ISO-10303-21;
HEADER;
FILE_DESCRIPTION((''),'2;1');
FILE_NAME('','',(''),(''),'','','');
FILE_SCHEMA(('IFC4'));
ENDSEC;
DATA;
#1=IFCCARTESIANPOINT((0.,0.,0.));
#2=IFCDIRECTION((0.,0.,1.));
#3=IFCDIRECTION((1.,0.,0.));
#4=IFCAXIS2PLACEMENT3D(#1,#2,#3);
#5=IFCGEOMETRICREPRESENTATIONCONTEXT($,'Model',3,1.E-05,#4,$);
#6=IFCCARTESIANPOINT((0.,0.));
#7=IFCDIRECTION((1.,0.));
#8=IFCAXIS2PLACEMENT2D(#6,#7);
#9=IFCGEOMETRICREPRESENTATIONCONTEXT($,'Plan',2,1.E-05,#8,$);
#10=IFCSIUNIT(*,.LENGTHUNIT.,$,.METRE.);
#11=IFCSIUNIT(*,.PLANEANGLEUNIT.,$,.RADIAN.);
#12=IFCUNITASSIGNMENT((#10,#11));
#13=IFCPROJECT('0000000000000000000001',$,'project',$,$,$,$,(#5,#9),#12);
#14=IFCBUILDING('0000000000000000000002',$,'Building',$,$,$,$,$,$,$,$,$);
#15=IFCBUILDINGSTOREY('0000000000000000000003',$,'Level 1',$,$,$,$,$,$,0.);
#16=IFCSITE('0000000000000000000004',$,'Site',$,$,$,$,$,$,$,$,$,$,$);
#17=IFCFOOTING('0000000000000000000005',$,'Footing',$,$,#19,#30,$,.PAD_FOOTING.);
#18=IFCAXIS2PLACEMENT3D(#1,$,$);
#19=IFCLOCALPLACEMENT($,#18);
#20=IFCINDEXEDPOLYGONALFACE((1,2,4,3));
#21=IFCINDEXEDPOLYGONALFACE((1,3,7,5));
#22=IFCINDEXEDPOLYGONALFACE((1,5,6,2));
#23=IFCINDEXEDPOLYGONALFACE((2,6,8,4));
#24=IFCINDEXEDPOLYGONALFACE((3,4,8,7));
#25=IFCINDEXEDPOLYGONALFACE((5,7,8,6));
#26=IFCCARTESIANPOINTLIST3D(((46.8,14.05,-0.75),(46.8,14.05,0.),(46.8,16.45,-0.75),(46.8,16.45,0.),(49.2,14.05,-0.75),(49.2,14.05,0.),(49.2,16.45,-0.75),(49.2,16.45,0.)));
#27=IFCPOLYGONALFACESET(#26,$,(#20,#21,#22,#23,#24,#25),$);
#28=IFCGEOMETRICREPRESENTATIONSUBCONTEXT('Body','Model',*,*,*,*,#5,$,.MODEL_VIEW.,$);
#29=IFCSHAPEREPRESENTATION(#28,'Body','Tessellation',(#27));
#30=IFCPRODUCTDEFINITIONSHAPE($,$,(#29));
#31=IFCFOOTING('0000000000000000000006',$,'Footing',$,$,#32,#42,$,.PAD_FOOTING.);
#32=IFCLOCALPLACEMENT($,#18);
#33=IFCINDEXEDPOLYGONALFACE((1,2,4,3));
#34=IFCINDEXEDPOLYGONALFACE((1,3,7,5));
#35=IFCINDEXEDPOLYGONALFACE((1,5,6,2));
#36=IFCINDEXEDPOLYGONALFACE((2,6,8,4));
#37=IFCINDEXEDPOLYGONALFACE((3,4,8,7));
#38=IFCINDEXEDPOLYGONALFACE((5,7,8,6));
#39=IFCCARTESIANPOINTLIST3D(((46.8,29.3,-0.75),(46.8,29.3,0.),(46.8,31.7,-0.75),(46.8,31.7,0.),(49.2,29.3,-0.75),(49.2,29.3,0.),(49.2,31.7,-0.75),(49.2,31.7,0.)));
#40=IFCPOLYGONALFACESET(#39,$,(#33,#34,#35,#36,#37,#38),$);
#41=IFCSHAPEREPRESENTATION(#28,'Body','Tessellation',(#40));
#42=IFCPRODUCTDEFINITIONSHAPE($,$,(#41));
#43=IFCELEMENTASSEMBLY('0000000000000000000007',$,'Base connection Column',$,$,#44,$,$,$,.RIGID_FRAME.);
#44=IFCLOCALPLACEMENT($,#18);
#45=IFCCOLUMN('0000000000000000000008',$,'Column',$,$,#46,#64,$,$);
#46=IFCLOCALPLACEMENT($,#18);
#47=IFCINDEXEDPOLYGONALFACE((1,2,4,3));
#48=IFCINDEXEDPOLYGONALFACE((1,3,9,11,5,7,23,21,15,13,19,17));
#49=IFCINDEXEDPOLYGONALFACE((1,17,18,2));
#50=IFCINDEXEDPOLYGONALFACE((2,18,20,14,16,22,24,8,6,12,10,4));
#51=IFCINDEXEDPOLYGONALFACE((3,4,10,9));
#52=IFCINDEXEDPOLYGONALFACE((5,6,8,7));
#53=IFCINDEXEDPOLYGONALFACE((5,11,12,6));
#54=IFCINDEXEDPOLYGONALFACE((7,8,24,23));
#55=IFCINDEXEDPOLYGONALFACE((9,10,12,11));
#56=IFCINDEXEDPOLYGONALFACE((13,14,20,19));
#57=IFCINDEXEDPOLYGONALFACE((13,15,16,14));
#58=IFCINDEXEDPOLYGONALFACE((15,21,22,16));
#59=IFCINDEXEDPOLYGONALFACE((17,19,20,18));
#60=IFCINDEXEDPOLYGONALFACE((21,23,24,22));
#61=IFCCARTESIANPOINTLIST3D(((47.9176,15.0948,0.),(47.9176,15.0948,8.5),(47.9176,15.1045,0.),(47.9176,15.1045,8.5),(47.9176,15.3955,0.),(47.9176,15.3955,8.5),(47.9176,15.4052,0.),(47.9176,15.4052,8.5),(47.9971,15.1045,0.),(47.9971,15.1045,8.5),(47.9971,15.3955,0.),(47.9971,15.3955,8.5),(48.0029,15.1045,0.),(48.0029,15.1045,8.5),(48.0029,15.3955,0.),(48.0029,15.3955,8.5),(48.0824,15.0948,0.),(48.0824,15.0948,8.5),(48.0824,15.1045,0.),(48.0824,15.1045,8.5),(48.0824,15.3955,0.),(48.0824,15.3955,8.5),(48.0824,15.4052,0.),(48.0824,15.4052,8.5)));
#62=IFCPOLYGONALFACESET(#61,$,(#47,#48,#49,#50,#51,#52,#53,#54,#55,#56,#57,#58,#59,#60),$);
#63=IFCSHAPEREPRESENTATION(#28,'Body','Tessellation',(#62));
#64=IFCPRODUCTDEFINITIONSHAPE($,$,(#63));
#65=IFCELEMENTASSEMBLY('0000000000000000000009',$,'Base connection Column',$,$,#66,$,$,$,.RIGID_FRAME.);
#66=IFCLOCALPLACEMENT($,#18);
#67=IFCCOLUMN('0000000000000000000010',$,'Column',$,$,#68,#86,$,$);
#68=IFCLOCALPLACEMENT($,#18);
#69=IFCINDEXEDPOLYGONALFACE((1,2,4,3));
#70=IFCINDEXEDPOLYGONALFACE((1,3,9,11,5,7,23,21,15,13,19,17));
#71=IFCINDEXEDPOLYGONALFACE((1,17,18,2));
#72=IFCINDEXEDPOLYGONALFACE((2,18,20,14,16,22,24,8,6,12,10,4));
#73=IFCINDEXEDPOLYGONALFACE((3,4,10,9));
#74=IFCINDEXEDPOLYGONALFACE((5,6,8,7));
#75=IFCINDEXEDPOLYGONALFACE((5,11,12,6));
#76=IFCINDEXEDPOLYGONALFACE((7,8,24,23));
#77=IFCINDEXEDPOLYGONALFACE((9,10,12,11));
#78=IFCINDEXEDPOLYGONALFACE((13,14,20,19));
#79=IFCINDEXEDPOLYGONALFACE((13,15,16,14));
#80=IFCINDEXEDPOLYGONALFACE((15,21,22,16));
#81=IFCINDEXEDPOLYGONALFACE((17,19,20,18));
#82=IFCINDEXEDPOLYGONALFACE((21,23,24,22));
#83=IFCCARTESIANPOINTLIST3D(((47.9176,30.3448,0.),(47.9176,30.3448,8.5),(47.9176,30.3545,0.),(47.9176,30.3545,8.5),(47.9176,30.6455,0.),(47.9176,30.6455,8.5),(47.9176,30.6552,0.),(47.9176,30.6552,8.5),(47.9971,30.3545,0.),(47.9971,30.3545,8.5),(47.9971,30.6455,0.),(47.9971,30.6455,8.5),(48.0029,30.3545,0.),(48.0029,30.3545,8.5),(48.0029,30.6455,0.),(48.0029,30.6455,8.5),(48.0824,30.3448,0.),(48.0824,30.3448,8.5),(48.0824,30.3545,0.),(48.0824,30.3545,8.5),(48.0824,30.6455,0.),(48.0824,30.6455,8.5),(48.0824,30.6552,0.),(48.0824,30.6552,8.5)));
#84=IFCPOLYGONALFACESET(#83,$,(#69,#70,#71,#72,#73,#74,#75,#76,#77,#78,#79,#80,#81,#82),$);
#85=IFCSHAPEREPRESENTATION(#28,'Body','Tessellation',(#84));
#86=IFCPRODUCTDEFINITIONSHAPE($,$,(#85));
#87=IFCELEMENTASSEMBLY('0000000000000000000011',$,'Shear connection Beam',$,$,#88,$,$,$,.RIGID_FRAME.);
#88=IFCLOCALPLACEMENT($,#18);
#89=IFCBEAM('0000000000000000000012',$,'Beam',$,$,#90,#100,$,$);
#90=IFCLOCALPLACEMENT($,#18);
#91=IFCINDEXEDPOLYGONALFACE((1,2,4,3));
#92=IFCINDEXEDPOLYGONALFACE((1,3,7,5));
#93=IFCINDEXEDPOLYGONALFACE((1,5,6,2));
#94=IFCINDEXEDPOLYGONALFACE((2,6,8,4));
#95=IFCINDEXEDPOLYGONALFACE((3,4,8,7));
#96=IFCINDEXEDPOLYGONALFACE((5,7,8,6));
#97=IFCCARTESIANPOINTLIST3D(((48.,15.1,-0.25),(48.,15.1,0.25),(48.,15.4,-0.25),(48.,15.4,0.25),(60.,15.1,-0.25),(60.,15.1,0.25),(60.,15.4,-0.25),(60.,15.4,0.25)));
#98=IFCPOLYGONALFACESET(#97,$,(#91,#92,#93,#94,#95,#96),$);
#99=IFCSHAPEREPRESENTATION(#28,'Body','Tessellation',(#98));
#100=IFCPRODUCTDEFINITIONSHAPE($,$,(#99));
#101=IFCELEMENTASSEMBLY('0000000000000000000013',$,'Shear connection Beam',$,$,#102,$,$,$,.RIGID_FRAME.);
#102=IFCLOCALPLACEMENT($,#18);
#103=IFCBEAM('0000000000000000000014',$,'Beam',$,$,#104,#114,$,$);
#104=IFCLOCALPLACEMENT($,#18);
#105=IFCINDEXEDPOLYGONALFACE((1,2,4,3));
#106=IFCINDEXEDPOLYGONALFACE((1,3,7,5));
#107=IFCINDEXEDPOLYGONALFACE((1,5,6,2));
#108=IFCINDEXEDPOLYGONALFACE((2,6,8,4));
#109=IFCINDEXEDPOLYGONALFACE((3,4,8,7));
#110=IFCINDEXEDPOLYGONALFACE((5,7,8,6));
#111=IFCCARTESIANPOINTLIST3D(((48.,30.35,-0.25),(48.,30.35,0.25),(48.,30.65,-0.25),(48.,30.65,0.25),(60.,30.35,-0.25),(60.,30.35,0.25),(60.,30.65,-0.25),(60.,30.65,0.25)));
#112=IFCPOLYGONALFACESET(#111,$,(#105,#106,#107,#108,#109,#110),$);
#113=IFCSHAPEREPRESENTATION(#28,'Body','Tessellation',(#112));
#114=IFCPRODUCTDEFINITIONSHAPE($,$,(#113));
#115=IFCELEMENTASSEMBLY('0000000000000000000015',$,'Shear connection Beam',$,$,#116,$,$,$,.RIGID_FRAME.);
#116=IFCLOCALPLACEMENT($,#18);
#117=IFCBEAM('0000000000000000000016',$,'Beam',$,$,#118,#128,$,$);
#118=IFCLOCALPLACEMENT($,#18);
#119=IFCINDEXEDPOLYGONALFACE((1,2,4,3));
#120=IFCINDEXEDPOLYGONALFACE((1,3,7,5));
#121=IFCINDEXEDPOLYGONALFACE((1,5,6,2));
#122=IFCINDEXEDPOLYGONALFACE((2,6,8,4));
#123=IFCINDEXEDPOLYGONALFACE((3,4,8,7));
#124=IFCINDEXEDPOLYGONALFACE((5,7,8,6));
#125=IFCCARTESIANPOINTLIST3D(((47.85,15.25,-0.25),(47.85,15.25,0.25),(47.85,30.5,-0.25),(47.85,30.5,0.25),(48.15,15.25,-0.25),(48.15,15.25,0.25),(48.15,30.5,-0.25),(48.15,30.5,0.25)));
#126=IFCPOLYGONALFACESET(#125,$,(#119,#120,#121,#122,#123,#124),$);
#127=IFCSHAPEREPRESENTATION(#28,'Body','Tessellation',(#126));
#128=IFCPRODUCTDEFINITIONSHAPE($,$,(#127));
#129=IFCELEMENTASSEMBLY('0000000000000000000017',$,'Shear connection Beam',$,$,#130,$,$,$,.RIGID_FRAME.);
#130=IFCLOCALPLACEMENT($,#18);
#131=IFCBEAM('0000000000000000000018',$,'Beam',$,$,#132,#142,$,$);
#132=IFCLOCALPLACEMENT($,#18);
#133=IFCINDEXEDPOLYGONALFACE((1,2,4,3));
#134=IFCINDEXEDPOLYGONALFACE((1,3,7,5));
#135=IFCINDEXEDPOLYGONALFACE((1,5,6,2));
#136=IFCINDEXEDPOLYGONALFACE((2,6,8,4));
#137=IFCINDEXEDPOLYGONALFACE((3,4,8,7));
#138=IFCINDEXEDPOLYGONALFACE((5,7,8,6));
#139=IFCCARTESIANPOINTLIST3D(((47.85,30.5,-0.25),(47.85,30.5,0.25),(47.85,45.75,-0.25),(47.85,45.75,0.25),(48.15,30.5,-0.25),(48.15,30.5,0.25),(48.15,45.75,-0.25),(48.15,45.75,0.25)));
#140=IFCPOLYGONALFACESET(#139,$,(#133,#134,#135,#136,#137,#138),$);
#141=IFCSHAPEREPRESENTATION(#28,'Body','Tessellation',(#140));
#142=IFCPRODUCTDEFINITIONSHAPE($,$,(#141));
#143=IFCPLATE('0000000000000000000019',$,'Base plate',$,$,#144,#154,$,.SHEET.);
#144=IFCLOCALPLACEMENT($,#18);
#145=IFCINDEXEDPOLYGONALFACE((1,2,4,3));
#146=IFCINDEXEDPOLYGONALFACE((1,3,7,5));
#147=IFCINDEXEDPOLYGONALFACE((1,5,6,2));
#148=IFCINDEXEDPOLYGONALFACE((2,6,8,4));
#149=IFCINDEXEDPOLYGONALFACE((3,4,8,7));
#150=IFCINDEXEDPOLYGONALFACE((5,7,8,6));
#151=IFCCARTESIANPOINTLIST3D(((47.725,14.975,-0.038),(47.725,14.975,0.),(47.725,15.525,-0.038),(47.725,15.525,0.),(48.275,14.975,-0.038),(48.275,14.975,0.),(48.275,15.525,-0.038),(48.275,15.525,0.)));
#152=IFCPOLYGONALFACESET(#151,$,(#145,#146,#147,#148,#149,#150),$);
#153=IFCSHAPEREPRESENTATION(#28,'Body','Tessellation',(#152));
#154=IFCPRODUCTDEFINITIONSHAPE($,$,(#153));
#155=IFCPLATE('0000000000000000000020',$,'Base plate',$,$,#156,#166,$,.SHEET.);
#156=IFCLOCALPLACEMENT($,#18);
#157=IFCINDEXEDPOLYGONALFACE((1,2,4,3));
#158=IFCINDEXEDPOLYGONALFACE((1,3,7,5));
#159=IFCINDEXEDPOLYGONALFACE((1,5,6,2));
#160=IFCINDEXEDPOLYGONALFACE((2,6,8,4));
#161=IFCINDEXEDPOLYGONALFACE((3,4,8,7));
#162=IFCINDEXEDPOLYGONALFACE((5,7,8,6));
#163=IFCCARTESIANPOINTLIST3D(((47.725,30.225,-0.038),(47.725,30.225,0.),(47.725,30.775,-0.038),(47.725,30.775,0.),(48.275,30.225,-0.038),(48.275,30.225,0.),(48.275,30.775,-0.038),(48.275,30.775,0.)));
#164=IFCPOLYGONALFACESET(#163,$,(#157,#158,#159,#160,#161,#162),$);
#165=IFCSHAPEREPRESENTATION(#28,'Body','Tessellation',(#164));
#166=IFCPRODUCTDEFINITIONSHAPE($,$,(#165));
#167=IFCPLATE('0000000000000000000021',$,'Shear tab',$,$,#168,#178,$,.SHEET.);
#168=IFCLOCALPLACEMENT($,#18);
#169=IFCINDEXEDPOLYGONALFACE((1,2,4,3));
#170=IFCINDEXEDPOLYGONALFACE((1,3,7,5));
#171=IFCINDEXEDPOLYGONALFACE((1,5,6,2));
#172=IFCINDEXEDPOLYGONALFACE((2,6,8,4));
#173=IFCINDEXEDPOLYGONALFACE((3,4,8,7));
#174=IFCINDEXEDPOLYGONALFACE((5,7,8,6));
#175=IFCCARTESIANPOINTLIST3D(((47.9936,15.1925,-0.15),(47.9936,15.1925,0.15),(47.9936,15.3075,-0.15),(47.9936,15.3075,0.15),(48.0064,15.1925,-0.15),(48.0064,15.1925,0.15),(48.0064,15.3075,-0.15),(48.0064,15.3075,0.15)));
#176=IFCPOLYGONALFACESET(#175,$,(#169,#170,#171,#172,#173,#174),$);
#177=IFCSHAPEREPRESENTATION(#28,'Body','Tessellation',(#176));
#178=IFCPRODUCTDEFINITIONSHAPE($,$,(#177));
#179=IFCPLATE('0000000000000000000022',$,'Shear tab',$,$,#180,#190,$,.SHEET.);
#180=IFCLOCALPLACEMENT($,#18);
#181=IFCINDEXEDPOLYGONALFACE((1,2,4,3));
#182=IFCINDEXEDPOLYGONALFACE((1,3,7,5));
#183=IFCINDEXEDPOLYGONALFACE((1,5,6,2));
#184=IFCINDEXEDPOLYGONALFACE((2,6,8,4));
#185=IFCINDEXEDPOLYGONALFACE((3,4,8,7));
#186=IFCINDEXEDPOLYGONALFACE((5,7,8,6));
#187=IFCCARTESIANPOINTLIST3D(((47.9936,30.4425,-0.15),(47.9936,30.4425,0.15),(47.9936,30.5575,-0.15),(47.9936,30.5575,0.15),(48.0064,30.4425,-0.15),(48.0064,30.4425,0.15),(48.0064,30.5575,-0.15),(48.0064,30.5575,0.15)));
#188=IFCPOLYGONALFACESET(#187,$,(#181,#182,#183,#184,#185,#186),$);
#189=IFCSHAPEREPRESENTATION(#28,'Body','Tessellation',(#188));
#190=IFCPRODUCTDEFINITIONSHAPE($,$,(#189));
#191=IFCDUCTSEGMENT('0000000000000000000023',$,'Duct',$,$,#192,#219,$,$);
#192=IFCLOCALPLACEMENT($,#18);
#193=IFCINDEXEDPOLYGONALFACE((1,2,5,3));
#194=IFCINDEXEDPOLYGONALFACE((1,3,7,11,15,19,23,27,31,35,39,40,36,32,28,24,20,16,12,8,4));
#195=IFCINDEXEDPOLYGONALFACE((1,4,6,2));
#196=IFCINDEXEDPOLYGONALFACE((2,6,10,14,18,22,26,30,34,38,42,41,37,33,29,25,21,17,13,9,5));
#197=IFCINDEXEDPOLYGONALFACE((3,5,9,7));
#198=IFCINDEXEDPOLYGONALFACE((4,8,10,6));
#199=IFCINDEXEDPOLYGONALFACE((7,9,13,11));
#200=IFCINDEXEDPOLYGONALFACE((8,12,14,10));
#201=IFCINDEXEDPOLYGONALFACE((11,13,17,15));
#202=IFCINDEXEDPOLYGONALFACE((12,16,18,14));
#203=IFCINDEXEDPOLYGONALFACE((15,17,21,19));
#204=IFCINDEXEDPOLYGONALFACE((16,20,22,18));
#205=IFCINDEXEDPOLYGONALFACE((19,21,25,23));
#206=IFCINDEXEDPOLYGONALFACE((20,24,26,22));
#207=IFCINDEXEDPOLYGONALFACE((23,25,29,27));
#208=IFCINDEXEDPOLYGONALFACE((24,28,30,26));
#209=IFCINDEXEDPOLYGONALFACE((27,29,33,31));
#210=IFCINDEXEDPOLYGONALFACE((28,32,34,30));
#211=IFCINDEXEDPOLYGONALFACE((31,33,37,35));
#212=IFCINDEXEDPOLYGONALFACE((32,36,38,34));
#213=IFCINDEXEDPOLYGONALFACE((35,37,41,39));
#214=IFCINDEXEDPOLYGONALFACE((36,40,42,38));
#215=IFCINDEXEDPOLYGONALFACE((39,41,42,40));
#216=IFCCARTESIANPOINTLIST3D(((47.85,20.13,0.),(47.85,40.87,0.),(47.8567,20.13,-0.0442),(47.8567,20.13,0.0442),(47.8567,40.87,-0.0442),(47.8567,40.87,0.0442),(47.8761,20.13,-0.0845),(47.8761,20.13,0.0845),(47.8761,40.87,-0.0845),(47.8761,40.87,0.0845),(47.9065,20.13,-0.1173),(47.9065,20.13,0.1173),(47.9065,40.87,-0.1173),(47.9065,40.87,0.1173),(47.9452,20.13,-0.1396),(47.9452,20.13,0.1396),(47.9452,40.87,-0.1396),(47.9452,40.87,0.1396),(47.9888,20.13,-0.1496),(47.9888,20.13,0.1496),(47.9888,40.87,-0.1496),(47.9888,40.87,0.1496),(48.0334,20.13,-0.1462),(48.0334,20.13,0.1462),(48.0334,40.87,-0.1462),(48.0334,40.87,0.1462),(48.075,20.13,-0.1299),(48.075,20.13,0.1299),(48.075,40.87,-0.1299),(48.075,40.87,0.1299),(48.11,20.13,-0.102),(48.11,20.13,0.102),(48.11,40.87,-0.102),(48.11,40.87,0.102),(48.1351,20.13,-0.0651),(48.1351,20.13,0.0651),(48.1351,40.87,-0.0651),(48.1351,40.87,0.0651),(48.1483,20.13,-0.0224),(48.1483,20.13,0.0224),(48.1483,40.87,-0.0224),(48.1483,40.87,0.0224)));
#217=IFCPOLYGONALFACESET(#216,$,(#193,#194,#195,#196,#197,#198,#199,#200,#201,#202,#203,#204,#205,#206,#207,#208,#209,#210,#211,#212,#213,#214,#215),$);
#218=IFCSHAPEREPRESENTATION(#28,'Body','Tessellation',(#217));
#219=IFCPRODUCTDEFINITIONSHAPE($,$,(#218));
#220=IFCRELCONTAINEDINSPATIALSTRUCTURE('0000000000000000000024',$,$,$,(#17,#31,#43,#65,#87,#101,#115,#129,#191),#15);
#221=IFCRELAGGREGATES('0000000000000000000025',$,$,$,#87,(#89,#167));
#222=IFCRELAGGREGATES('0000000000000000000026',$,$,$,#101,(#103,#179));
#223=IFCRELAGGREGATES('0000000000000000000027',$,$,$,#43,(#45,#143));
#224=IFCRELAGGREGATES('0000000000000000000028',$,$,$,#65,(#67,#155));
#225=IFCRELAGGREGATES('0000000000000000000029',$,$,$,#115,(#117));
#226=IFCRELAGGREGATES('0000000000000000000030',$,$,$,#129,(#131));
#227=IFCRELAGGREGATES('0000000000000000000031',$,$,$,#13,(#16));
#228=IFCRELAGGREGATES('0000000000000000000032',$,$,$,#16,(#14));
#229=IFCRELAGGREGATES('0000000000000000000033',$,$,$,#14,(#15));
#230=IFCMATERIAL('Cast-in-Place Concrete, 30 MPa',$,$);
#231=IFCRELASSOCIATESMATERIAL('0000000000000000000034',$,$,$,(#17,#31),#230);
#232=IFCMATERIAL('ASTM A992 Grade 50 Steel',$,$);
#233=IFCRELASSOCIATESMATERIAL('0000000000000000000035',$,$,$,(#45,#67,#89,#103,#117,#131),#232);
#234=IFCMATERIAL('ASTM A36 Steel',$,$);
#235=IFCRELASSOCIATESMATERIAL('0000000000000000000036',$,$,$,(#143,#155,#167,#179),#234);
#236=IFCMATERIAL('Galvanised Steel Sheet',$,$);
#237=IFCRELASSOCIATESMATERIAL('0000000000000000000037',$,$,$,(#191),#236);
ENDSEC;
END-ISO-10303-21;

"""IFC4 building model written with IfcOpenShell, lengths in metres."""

from ifc_helpers import new_model, si_unit, frame, origin_with_axes, origin_2d_with_axis, place, context, subcontext, project, spatial, rectangle, circle, i_section, extrude, material, element, aggregate, save


model = new_model("IFC4")

# Units and contexts
model_context = context("Model", 3, precision=1e-05, world=origin_with_axes())
plan_context = context("Plan", 2, precision=1e-05, world=origin_2d_with_axis())
body_context = subcontext(model_context, "Body", "Model", "MODEL_VIEW")
ifc_project = project(units=[si_unit("LENGTHUNIT", "METRE"), si_unit("PLANEANGLEUNIT", "RADIAN")], contexts=[model_context, plan_context])

# Site, building, storey
site = spatial("IfcSite", under=ifc_project, Name="Site")
building = spatial("IfcBuilding", under=site, Name="Building")
storey = spatial("IfcBuildingStorey", under=building, Name="Level 1", Elevation=0.0)

# Footings
ifc_material_1 = material(Name="Cast-in-Place Concrete, 30 MPa")
for number, where, z_axis, x_axis, name in (
    (1, (48.0, 15.25, -0.75), (0.0, 0.0, 1.0), (1.0, 0.0, 0.0), "Footing"),
    (2, (48.0, 30.5, -0.75), (0.0, 0.0, 1.0), (1.0, 0.0, 0.0), "Footing"),
):
    element("IfcFooting", number, at=place(None, frame(where, z_axis=z_axis, x_axis=x_axis)), inside=storey, material=ifc_material_1, Name=name, PredefinedType="PAD_FOOTING", context=body_context, shape_type="SweptSolid", body=[
        extrude(rectangle(XDim=2.4, YDim=2.4, at=origin_2d_with_axis()), origin_with_axes(), (0.0, 0.0, 1.0), 0.75),
    ])

# Element assemblies, columns
assembly_1 = element("IfcElementAssembly", 3, inside=storey, Name="Base connection Column", PredefinedType="RIGID_FRAME")
ifc_material_2 = material(Name="ASTM A992 Grade 50 Steel")
column_1_placement = place(None, frame((48.0, 15.25, 0.0), z_axis=(0.0, 0.0, 1.0), x_axis=(1.0, 0.0, 0.0)))
column_1 = element("IfcColumn", 4, at=column_1_placement, material=ifc_material_2, Name="Column", context=body_context, shape_type="SweptSolid", body=[
    extrude(i_section(OverallWidth=0.1648, OverallDepth=0.3104, WebThickness=0.0058, FlangeThickness=0.0097, at=origin_2d_with_axis()), origin_with_axes(), (0.0, 0.0, 1.0), 8.5),
])
assembly_2 = element("IfcElementAssembly", 5, inside=storey, Name="Base connection Column", PredefinedType="RIGID_FRAME")
column_2_placement = place(None, frame((48.0, 30.5, 0.0), z_axis=(0.0, 0.0, 1.0), x_axis=(1.0, 0.0, 0.0)))
column_2 = element("IfcColumn", 6, at=column_2_placement, material=ifc_material_2, Name="Column", context=body_context, shape_type="SweptSolid", body=[
    extrude(i_section(OverallWidth=0.1648, OverallDepth=0.3104, WebThickness=0.0058, FlangeThickness=0.0097, at=origin_2d_with_axis()), origin_with_axes(), (0.0, 0.0, 1.0), 8.5),
])

# Element assemblies, beams
assembly_3 = element("IfcElementAssembly", 7, inside=storey, Name="Shear connection Beam", PredefinedType="RIGID_FRAME")
beam_1_placement = place(None, frame((48.0, 15.25, 0.0), z_axis=(1.0, 0.0, 0.0), x_axis=(0.0, 1.0, 0.0)))
beam_1 = element("IfcBeam", 8, at=beam_1_placement, material=ifc_material_2, Name="Beam", context=body_context, shape_type="SweptSolid", body=[
    extrude(rectangle(XDim=0.3, YDim=0.5, at=origin_2d_with_axis()), origin_with_axes(), (0.0, 0.0, 1.0), 12.0),
])
assembly_4 = element("IfcElementAssembly", 9, inside=storey, Name="Shear connection Beam", PredefinedType="RIGID_FRAME")
beam_2_placement = place(None, frame((48.0, 30.5, 0.0), z_axis=(1.0, 0.0, 0.0), x_axis=(0.0, 1.0, 0.0)))
beam_2 = element("IfcBeam", 10, at=beam_2_placement, material=ifc_material_2, Name="Beam", context=body_context, shape_type="SweptSolid", body=[
    extrude(rectangle(XDim=0.3, YDim=0.5, at=origin_2d_with_axis()), origin_with_axes(), (0.0, 0.0, 1.0), 12.0),
])
assembly_5 = element("IfcElementAssembly", 11, inside=storey, Name="Shear connection Beam", PredefinedType="RIGID_FRAME")
beam_3_placement = place(None, frame((48.0, 15.25, 0.0), z_axis=(0.0, 1.0, 0.0), x_axis=(-1.0, 0.0, 0.0)))
beam_3 = element("IfcBeam", 12, at=beam_3_placement, material=ifc_material_2, Name="Beam", context=body_context, shape_type="SweptSolid", body=[
    extrude(rectangle(XDim=0.3, YDim=0.5, at=origin_2d_with_axis()), origin_with_axes(), (0.0, 0.0, 1.0), 15.25),
])
assembly_6 = element("IfcElementAssembly", 13, inside=storey, Name="Shear connection Beam", PredefinedType="RIGID_FRAME")
beam_4_placement = place(None, frame((48.0, 30.5, 0.0), z_axis=(0.0, 1.0, 0.0), x_axis=(-1.0, 0.0, 0.0)))
beam_4 = element("IfcBeam", 14, at=beam_4_placement, material=ifc_material_2, Name="Beam", context=body_context, shape_type="SweptSolid", body=[
    extrude(rectangle(XDim=0.3, YDim=0.5, at=origin_2d_with_axis()), origin_with_axes(), (0.0, 0.0, 1.0), 15.25),
])

# Plates
ifc_material_3 = material(Name="ASTM A36 Steel")
plate_1_placement = place(None, frame((48.0, 15.25, -0.038), z_axis=(0.0, 0.0, 1.0), x_axis=(1.0, 0.0, 0.0)))
plate_1 = element("IfcPlate", 15, at=plate_1_placement, material=ifc_material_3, Name="Base plate", PredefinedType="SHEET", context=body_context, shape_type="SweptSolid", body=[
    extrude(rectangle(XDim=0.55, YDim=0.55, at=origin_2d_with_axis()), origin_with_axes(), (0.0, 0.0, 1.0), 0.038),
])
plate_2_placement = place(None, frame((48.0, 30.5, -0.038), z_axis=(0.0, 0.0, 1.0), x_axis=(1.0, 0.0, 0.0)))
plate_2 = element("IfcPlate", 16, at=plate_2_placement, material=ifc_material_3, Name="Base plate", PredefinedType="SHEET", context=body_context, shape_type="SweptSolid", body=[
    extrude(rectangle(XDim=0.55, YDim=0.55, at=origin_2d_with_axis()), origin_with_axes(), (0.0, 0.0, 1.0), 0.038),
])
plate_3_placement = place(None, frame((48.0, 15.25, -0.15), z_axis=(0.0, 0.0, 1.0), x_axis=(1.0, 0.0, 0.0)))
plate_3 = element("IfcPlate", 17, at=plate_3_placement, material=ifc_material_3, Name="Shear tab", PredefinedType="SHEET", context=body_context, shape_type="SweptSolid", body=[
    extrude(rectangle(XDim=0.0127, YDim=0.115, at=origin_2d_with_axis()), origin_with_axes(), (0.0, 0.0, 1.0), 0.3),
])
aggregate(assembly_3, [beam_1, plate_3])
plate_4_placement = place(None, frame((48.0, 30.5, -0.15), z_axis=(0.0, 0.0, 1.0), x_axis=(1.0, 0.0, 0.0)))
plate_4 = element("IfcPlate", 18, at=plate_4_placement, material=ifc_material_3, Name="Shear tab", PredefinedType="SHEET", context=body_context, shape_type="SweptSolid", body=[
    extrude(rectangle(XDim=0.0127, YDim=0.115, at=origin_2d_with_axis()), origin_with_axes(), (0.0, 0.0, 1.0), 0.3),
])
aggregate(assembly_4, [beam_2, plate_4])

# Duct segment
ifc_material_4 = material(Name="Galvanised Steel Sheet")
duct_segment_placement = place(None, frame((48.0, 20.13, 0.0), z_axis=(0.0, 1.0, 0.0), x_axis=(-1.0, 0.0, 0.0)))
element("IfcDuctSegment", 19, at=duct_segment_placement, inside=storey, material=ifc_material_4, Name="Duct", context=body_context, shape_type="SweptSolid", body=[
    extrude(circle(Radius=0.15, at=origin_2d_with_axis()), origin_with_axes(), (0.0, 0.0, 1.0), 20.74),
])

aggregate(assembly_1, [column_1, plate_1])
aggregate(assembly_2, [column_2, plate_2])

aggregate(assembly_5, [beam_3])
aggregate(assembly_6, [beam_4])

save(model, "model.ifc")
